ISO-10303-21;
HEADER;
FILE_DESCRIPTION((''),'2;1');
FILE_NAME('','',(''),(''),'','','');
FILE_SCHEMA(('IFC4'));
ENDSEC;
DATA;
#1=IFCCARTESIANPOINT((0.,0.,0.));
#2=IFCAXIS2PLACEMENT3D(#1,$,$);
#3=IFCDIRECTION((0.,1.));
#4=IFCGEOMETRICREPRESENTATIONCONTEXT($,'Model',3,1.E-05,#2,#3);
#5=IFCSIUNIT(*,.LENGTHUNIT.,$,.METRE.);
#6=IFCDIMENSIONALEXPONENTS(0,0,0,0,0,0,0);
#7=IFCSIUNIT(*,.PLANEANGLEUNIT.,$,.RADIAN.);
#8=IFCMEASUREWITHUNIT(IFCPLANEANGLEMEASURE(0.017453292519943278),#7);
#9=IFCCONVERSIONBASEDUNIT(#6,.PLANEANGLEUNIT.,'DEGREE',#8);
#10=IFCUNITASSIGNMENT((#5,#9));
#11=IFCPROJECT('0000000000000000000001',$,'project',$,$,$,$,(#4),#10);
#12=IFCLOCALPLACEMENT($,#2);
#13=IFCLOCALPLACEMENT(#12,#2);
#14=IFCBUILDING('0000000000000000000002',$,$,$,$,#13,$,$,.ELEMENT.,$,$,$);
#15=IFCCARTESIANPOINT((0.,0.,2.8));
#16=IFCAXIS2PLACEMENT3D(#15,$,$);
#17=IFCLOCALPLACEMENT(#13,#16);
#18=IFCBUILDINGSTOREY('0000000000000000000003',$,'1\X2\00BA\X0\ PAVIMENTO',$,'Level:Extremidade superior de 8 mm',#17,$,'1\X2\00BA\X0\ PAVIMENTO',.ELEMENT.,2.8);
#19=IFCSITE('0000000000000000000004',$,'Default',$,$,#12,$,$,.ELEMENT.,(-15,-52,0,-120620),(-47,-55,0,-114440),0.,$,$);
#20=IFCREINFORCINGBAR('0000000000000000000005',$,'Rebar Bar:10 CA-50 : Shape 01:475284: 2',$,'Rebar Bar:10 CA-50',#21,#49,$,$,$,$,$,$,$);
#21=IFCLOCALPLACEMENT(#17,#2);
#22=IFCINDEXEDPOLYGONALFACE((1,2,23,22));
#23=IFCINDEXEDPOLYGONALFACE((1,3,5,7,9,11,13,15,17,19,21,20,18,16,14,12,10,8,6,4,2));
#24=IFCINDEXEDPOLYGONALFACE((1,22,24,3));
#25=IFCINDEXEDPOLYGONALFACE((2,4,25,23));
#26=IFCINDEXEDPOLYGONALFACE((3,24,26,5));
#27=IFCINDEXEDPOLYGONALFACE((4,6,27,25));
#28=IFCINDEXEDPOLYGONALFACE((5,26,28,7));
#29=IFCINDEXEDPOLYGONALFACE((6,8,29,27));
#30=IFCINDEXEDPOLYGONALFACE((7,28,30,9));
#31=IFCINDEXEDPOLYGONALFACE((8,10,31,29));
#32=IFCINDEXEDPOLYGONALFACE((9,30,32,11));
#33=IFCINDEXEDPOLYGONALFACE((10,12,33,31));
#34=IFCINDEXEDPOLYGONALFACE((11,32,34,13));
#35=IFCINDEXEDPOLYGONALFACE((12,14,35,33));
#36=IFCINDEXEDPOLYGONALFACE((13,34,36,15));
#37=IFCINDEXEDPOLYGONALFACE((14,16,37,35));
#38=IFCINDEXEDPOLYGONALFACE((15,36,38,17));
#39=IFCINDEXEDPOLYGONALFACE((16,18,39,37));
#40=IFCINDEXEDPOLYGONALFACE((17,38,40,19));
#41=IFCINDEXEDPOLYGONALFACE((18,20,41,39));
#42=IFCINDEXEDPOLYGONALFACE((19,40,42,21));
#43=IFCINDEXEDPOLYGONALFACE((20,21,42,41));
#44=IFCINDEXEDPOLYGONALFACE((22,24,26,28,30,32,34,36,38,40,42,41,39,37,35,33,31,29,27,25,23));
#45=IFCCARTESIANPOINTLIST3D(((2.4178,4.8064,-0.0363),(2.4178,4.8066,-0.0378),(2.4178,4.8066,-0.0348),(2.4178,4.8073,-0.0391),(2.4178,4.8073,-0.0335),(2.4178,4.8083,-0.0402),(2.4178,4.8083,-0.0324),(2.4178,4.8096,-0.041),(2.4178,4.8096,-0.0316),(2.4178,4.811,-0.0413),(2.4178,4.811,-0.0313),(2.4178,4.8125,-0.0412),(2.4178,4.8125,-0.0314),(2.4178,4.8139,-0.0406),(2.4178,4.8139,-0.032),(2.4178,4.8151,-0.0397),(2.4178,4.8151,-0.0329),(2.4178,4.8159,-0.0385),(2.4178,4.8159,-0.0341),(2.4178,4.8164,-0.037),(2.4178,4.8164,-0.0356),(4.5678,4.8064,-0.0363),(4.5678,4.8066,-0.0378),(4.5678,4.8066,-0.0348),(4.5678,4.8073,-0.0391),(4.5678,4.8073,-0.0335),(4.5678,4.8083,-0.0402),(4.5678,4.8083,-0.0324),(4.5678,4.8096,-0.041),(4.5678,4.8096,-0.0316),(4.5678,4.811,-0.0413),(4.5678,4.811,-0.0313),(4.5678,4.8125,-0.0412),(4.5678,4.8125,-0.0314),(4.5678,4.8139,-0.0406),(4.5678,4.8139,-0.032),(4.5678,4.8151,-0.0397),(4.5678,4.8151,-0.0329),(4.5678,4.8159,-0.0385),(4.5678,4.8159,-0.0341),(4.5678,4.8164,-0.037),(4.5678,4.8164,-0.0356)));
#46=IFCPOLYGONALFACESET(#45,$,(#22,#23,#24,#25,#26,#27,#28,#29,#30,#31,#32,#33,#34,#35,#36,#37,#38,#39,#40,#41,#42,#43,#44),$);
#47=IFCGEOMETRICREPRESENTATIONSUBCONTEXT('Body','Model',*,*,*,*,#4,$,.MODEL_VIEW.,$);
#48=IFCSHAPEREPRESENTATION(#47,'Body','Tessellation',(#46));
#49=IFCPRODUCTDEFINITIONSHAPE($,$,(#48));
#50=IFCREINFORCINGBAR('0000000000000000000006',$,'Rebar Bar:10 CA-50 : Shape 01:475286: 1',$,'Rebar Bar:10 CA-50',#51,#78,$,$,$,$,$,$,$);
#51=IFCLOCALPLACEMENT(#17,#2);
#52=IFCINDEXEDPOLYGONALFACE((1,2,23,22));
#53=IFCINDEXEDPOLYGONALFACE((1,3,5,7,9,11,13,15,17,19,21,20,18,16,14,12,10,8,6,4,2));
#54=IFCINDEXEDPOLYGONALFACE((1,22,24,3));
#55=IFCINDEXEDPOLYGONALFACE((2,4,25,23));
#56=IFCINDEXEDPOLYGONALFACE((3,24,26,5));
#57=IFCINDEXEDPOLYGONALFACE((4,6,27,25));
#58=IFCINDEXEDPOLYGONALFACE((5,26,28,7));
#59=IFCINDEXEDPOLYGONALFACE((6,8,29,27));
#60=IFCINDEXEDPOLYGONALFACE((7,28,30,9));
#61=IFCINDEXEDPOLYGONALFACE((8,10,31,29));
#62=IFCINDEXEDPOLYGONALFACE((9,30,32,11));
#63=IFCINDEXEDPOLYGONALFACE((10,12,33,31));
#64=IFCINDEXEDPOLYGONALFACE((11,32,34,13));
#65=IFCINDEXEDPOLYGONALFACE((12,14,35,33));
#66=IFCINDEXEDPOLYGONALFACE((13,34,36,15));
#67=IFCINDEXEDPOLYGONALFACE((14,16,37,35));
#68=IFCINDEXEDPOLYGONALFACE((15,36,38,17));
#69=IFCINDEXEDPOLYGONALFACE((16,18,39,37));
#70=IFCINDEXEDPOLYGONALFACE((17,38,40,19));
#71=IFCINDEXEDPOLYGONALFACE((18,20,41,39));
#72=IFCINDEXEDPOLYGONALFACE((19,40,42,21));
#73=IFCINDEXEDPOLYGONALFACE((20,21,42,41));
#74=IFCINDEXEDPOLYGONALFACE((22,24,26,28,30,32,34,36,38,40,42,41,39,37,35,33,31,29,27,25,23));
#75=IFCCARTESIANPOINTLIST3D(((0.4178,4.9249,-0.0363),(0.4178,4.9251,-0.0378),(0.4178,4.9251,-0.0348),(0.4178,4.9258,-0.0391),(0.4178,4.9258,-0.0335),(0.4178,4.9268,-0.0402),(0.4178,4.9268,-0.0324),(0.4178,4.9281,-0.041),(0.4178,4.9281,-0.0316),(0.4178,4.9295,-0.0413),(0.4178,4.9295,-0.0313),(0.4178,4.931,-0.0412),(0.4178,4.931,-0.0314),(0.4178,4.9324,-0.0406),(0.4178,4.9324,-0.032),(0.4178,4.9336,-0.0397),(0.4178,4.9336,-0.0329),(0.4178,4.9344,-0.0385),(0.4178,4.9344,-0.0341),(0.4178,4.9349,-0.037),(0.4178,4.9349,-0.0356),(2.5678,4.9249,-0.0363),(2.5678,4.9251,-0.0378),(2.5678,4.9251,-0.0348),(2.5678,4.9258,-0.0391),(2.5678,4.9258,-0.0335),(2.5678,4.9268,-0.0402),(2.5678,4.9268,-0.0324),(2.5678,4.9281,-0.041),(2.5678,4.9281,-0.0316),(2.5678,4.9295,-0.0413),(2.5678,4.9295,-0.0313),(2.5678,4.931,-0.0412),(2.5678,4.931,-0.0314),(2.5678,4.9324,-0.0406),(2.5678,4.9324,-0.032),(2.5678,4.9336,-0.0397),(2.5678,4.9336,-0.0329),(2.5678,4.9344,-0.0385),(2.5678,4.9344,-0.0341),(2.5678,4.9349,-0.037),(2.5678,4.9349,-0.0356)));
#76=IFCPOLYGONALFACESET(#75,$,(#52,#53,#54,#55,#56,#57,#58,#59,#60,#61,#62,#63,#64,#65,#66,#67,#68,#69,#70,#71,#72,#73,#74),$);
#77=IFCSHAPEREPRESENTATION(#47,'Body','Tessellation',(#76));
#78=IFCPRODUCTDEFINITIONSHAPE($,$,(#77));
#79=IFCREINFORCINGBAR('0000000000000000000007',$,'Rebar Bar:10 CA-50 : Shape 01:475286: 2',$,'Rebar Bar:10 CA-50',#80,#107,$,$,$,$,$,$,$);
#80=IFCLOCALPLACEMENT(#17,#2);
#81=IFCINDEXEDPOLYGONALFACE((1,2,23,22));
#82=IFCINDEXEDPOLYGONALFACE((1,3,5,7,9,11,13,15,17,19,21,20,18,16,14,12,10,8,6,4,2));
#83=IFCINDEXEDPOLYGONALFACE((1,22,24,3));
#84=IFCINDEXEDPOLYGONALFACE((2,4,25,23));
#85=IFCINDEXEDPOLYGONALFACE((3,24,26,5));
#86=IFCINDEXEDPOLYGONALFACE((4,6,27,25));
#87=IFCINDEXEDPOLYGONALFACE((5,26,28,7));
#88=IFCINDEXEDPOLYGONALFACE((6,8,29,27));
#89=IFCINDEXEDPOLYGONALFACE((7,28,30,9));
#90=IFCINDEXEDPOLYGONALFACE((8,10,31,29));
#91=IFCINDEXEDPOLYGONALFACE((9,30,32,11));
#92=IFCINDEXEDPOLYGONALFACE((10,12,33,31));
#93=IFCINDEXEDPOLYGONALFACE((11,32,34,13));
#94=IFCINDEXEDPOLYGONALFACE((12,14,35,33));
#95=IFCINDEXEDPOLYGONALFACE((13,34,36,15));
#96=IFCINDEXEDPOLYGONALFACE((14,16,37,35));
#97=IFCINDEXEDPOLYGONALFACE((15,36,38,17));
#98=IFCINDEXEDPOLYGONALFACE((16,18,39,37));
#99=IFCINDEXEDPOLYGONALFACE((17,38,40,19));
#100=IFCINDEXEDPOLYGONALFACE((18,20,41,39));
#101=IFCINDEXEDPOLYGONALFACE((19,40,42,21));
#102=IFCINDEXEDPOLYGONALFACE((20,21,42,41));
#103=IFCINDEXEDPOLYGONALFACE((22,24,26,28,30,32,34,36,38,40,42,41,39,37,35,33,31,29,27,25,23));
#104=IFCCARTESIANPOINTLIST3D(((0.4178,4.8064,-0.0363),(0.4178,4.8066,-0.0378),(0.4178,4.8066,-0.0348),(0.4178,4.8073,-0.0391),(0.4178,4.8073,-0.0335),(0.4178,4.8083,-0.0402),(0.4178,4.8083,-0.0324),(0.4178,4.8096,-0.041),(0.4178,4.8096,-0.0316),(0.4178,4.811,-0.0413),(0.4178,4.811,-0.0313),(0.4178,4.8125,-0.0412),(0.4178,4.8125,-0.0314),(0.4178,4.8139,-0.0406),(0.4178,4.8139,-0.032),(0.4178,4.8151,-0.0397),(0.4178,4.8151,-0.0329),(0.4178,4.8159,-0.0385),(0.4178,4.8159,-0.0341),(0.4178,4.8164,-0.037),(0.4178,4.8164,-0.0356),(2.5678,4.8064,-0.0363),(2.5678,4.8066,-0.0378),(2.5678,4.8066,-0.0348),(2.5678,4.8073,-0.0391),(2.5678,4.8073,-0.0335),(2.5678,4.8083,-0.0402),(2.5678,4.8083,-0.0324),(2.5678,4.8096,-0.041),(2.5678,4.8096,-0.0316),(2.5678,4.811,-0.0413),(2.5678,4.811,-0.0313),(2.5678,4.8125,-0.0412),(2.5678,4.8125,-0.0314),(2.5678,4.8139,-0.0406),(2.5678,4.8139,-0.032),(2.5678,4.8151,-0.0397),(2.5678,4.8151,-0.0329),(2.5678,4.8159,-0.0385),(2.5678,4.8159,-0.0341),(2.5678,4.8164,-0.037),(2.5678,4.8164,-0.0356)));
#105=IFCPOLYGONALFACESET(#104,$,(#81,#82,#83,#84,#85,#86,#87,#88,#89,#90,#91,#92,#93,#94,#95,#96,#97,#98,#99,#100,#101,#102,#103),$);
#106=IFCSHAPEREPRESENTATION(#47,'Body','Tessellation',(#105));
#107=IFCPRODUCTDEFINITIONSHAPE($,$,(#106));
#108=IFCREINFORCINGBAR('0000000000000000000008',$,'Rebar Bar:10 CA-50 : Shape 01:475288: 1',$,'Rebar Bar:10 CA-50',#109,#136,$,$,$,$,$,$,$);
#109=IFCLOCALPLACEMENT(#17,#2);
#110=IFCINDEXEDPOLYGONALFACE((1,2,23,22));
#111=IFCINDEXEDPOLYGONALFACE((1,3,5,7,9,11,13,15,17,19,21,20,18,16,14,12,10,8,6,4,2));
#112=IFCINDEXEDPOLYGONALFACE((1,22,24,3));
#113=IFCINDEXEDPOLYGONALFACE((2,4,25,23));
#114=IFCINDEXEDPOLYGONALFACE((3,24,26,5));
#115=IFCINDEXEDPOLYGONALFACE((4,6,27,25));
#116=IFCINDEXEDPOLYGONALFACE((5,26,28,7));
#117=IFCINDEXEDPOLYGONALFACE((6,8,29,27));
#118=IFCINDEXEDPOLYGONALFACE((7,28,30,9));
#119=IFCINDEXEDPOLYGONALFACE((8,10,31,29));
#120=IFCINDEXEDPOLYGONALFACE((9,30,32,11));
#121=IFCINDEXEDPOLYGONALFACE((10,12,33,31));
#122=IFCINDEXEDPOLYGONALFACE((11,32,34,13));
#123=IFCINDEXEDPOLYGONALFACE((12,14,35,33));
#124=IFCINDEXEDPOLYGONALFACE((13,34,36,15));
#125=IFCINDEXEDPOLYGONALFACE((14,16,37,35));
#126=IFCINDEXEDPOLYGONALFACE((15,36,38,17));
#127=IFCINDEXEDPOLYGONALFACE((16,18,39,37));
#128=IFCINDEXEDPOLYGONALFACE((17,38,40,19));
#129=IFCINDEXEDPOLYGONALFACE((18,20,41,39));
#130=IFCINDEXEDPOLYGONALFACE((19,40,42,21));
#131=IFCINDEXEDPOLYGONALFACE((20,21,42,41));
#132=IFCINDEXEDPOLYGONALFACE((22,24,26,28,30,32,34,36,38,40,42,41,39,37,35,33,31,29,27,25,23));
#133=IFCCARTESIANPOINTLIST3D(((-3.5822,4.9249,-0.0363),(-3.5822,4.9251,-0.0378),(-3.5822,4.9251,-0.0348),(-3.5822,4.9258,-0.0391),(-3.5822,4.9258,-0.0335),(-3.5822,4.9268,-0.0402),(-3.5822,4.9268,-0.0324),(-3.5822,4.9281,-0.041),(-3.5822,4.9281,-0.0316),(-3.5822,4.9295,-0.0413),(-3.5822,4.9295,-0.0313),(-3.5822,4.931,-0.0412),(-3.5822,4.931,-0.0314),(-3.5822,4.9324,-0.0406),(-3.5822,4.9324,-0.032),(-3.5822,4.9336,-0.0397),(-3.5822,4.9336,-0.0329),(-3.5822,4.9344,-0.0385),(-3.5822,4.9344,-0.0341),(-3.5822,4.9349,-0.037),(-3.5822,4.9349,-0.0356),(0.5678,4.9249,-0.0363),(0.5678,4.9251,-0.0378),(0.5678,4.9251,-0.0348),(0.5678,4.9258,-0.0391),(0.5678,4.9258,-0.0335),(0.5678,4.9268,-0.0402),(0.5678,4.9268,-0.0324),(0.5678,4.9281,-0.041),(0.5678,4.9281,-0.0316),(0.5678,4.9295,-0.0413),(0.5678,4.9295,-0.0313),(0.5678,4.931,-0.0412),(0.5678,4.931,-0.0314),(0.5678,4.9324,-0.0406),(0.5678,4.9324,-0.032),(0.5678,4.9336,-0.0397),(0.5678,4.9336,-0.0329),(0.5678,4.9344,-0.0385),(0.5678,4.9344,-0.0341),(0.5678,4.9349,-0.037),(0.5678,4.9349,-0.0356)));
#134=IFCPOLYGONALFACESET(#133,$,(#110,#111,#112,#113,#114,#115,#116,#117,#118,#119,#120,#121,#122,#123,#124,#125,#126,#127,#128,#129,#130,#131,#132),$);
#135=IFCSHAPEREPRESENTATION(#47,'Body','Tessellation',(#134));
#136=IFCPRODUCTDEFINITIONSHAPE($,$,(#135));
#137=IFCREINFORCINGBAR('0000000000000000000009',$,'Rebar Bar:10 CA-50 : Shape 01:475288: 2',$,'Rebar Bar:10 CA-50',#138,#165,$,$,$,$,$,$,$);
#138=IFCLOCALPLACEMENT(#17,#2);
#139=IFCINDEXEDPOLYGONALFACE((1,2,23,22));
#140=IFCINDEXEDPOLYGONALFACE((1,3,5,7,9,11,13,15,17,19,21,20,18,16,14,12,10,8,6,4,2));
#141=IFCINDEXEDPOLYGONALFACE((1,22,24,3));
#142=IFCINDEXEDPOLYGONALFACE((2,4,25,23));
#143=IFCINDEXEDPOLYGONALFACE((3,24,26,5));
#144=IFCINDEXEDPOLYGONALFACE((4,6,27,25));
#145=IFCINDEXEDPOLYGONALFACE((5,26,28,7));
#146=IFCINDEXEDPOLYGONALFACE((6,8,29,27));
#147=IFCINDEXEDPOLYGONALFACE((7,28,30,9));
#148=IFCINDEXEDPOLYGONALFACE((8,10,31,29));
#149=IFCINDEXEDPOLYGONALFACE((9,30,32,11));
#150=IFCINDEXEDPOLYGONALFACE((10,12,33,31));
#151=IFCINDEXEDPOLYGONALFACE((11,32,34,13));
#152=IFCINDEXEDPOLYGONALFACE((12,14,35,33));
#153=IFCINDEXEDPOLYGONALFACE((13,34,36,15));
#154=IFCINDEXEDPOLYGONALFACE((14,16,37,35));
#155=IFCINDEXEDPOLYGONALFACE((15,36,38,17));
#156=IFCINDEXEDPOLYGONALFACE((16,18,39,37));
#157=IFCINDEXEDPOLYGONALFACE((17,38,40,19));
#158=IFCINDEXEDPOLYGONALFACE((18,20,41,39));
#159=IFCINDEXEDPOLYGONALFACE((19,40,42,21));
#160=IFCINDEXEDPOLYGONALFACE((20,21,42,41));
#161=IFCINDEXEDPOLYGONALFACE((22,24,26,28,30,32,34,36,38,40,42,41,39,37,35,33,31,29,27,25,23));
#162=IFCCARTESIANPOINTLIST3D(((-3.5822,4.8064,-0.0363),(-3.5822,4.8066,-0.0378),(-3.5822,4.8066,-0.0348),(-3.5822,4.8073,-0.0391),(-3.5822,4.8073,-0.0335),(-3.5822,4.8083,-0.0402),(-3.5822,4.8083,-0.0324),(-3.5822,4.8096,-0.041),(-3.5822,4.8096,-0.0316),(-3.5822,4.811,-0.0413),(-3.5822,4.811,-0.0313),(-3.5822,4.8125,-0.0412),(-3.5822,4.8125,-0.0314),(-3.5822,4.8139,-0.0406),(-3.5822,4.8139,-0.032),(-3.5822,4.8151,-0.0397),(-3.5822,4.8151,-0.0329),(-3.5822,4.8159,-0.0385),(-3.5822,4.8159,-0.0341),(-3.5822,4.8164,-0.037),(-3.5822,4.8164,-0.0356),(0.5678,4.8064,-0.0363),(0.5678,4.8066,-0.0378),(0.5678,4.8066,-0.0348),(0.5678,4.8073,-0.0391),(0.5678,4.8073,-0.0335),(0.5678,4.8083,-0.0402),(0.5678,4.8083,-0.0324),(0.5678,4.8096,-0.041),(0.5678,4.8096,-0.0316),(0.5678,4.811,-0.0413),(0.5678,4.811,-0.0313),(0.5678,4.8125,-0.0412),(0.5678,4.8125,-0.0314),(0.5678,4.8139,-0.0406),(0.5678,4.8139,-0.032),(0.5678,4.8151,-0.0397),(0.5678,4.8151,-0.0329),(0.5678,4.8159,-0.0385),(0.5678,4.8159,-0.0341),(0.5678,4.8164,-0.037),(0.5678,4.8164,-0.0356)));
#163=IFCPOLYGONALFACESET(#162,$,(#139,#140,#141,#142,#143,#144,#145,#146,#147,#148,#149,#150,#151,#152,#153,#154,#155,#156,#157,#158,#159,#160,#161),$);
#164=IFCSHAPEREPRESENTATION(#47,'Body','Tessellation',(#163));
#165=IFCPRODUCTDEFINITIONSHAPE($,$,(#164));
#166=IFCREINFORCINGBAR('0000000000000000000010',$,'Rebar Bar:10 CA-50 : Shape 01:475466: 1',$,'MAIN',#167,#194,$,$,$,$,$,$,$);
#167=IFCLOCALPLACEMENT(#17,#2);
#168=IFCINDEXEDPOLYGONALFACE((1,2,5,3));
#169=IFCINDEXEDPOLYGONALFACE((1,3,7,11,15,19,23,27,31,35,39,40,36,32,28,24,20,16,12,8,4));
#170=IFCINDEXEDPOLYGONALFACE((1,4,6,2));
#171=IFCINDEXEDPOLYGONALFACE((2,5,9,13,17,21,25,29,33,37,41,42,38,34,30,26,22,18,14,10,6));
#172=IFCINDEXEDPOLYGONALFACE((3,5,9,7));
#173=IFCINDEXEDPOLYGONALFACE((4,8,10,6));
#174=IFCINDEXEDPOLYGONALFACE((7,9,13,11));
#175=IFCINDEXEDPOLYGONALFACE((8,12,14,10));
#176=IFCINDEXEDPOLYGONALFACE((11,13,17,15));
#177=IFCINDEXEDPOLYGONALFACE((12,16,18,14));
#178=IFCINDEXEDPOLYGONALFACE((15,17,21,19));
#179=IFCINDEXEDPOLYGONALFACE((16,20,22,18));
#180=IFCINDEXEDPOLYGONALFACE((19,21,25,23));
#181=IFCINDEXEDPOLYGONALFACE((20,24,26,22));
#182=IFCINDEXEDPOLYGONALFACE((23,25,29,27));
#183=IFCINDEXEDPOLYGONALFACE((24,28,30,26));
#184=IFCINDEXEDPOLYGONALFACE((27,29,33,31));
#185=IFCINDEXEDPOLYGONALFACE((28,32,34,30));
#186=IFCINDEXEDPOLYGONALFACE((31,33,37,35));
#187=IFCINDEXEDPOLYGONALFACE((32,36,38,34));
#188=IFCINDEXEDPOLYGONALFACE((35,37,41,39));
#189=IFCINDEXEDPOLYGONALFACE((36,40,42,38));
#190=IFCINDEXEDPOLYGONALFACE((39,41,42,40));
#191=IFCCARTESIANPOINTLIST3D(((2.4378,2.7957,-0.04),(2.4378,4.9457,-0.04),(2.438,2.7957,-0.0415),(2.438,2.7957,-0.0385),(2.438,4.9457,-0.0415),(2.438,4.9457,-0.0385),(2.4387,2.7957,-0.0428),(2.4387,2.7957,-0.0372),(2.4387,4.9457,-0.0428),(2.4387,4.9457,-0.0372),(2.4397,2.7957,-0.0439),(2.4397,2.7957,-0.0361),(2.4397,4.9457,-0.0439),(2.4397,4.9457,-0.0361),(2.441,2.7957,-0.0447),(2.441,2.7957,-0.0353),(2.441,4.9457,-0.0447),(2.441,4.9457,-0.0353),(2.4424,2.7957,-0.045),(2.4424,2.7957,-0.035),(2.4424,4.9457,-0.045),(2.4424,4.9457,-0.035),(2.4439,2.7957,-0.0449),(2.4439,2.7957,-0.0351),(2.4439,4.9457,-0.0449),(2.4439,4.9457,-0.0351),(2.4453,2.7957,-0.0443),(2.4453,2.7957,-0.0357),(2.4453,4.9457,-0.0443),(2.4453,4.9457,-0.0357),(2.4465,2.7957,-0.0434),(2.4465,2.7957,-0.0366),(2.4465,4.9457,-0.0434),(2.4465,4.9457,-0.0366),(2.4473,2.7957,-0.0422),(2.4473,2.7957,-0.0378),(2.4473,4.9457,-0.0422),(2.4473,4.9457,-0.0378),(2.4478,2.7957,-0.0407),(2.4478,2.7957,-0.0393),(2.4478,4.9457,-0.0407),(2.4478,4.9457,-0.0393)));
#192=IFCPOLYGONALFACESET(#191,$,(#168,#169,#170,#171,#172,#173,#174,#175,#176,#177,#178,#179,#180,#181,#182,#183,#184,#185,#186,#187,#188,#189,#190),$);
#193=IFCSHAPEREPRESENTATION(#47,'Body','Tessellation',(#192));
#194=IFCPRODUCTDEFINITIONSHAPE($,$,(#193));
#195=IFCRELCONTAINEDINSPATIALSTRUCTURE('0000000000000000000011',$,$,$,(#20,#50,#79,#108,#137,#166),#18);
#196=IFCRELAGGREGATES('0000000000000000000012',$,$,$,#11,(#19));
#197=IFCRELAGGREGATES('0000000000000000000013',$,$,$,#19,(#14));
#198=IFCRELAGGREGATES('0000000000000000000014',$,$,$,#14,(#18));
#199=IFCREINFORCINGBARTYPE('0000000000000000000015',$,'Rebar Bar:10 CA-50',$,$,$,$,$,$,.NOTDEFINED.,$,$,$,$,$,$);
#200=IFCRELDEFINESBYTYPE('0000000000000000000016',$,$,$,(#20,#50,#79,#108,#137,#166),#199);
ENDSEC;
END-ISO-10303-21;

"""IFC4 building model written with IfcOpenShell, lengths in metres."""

from ifc_helpers import new_model, entity, si_unit, converted_unit, direction, frame, origin, place, context, subcontext, project, spatial, type_object, element, save


model = new_model("IFC4")

# Units and contexts
model_context = context("Model", 3, precision=1e-05, world=origin(), true_north=direction((0.0, 1.0)))
body_context = subcontext(model_context, "Body", "Model", "MODEL_VIEW")
ifc_project = project(units=[si_unit("LENGTHUNIT", "METRE"), converted_unit("PLANEANGLEUNIT", "DEGREE", entity("IfcPlaneAngleMeasure", 0.017453292519943278), si_unit("PLANEANGLEUNIT", "RADIAN"), dimensions=[0, 0, 0, 0, 0, 0, 0])], contexts=[model_context])

# Site, building, storey
site_placement = place(None, origin())
site = spatial("IfcSite", under=ifc_project, at=site_placement, Name="Default", CompositionType="ELEMENT", RefLatitude=(-15, -52, 0, -120620), RefLongitude=(-47, -55, 0, -114440), RefElevation=0.0)
building_placement = place(site_placement, origin())
building = spatial("IfcBuilding", under=site, at=building_placement, CompositionType="ELEMENT")
storey_placement = place(building_placement, frame((0.0, 0.0, 2.8)))
storey = spatial("IfcBuildingStorey", under=building, at=storey_placement, Name="1º PAVIMENTO", ObjectType="Level:Extremidade superior de 8 mm", LongName="1º PAVIMENTO", CompositionType="ELEMENT", Elevation=2.8)

# Reinforcing bars
reinforcing_bar_type = type_object("IfcReinforcingBarType", Name="Rebar Bar:10 CA-50", PredefinedType="NOTDEFINED")
reinforcing_bar_1_placement = place(storey_placement, origin())
element("IfcReinforcingBar", 1, at=reinforcing_bar_1_placement, inside=storey, type_object=reinforcing_bar_type, Name="Rebar Bar:10 CA-50 : Shape 01:475284: 2", ObjectType="Rebar Bar:10 CA-50", context=body_context, shape_type="AdvancedSweptSolid", body=[
    entity("IfcSweptDiskSolid", entity("IfcIndexedPolyCurve", entity("IfcCartesianPointList3D", [[4.5678, 4.8114, -0.0363], [2.4178, 4.8114, -0.0363]]), None, False), 0.005, None, 0.0, 1.0),
])
reinforcing_bar_2_placement = place(storey_placement, origin())
element("IfcReinforcingBar", 2, at=reinforcing_bar_2_placement, inside=storey, type_object=reinforcing_bar_type, Name="Rebar Bar:10 CA-50 : Shape 01:475286: 1", ObjectType="Rebar Bar:10 CA-50", context=body_context, shape_type="AdvancedSweptSolid", body=[
    entity("IfcSweptDiskSolid", entity("IfcIndexedPolyCurve", entity("IfcCartesianPointList3D", [[2.5678, 4.9299, -0.0363], [0.4178, 4.9299, -0.0363]]), None, False), 0.005, None, 0.0, 1.0),
])
reinforcing_bar_3_placement = place(storey_placement, origin())
element("IfcReinforcingBar", 3, at=reinforcing_bar_3_placement, inside=storey, type_object=reinforcing_bar_type, Name="Rebar Bar:10 CA-50 : Shape 01:475286: 2", ObjectType="Rebar Bar:10 CA-50", context=body_context, shape_type="AdvancedSweptSolid", body=[
    entity("IfcSweptDiskSolid", entity("IfcIndexedPolyCurve", entity("IfcCartesianPointList3D", [[2.5678, 4.8114, -0.0363], [0.4178, 4.8114, -0.0363]]), None, False), 0.005, None, 0.0, 1.0),
])
reinforcing_bar_4_placement = place(storey_placement, origin())
element("IfcReinforcingBar", 4, at=reinforcing_bar_4_placement, inside=storey, type_object=reinforcing_bar_type, Name="Rebar Bar:10 CA-50 : Shape 01:475288: 1", ObjectType="Rebar Bar:10 CA-50", context=body_context, shape_type="AdvancedSweptSolid", body=[
    entity("IfcSweptDiskSolid", entity("IfcIndexedPolyCurve", entity("IfcCartesianPointList3D", [[0.5678, 4.9299, -0.0363], [-3.5822, 4.9299, -0.0363]]), None, False), 0.005, None, 0.0, 1.0),
])
reinforcing_bar_5_placement = place(storey_placement, origin())
element("IfcReinforcingBar", 5, at=reinforcing_bar_5_placement, inside=storey, type_object=reinforcing_bar_type, Name="Rebar Bar:10 CA-50 : Shape 01:475288: 2", ObjectType="Rebar Bar:10 CA-50", context=body_context, shape_type="AdvancedSweptSolid", body=[
    entity("IfcSweptDiskSolid", entity("IfcIndexedPolyCurve", entity("IfcCartesianPointList3D", [[0.5678, 4.8114, -0.0363], [-3.5822, 4.8114, -0.0363]]), None, False), 0.005, None, 0.0, 1.0),
])
reinforcing_bar_6_placement = place(storey_placement, origin())
element("IfcReinforcingBar", 6, at=reinforcing_bar_6_placement, inside=storey, type_object=reinforcing_bar_type, Name="Rebar Bar:10 CA-50 : Shape 01:475466: 1", ObjectType="MAIN", context=body_context, shape_type="AdvancedSweptSolid", body=[
    entity("IfcSweptDiskSolid", entity("IfcIndexedPolyCurve", entity("IfcCartesianPointList3D", [[2.4428, 4.9457, -0.04], [2.4428, 2.7957, -0.04]]), None, False), 0.005, None, 0.0, 1.0),
])

save(model, "model.ifc")
